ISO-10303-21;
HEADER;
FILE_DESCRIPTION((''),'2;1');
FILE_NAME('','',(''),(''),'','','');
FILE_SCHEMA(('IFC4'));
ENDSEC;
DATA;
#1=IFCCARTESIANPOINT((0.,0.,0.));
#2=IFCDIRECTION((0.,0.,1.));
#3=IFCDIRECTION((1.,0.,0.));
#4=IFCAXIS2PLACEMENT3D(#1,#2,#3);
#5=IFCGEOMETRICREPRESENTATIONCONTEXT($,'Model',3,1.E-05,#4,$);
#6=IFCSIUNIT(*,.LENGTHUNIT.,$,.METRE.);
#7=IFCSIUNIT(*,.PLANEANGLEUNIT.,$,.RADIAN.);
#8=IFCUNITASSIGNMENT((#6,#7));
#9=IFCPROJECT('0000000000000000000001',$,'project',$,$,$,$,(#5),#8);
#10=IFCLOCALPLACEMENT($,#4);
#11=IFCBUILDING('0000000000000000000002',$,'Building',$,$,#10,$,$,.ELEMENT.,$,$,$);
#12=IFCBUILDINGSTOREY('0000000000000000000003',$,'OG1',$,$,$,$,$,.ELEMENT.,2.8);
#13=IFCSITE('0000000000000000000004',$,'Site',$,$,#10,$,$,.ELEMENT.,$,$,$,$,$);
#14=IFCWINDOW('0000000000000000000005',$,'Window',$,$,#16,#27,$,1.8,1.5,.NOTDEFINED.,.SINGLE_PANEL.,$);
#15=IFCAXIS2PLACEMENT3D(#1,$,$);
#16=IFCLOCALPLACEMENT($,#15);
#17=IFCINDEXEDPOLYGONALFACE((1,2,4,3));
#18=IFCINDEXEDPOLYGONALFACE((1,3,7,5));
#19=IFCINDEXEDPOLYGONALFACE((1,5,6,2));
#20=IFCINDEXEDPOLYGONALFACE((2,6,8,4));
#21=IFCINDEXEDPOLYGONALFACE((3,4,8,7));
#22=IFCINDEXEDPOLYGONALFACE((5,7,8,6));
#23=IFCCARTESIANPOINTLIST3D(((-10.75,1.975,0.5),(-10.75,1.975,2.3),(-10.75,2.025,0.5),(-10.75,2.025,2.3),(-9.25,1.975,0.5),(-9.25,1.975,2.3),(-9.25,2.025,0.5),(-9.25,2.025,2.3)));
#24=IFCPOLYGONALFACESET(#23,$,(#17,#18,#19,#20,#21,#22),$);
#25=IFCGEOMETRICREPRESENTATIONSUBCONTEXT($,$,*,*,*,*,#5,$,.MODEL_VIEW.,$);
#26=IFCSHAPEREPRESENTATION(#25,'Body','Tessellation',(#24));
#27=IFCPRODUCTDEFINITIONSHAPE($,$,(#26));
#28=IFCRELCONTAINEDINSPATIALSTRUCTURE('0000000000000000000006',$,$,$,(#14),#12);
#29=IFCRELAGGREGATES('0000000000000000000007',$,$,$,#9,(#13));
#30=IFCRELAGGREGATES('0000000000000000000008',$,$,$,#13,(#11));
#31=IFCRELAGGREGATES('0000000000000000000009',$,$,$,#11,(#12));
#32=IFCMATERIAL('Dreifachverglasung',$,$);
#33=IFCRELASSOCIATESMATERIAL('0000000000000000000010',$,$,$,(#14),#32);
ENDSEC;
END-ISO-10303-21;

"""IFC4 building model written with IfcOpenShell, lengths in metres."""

from ifc_helpers import new_model, si_unit, frame, origin, origin_with_axes, origin_2d, place, context, subcontext, project, spatial, rectangle, extrude, material, element, save


model = new_model("IFC4")

# Units and contexts
model_context = context("Model", 3, precision=1e-05, world=origin_with_axes())
sub_context = subcontext(model_context, None, None, "MODEL_VIEW")
ifc_project = project(units=[si_unit("LENGTHUNIT", "METRE"), si_unit("PLANEANGLEUNIT", "RADIAN")], contexts=[model_context])

# Site, building, storey
placement_1 = place(None, origin_with_axes())
site = spatial("IfcSite", under=ifc_project, at=placement_1, Name="Site", CompositionType="ELEMENT")
building = spatial("IfcBuilding", under=site, at=placement_1, Name="Building", CompositionType="ELEMENT")
storey = spatial("IfcBuildingStorey", under=building, Name="OG1", CompositionType="ELEMENT", Elevation=2.8)

# Window
ifc_material = material(Name="Dreifachverglasung")
placement_2 = place(None, origin_with_axes())
window_placement = place(placement_2, frame((-10.0, 2.0, 0.5)))
element("IfcWindow", 1, at=window_placement, inside=storey, material=ifc_material, Name="Window", OverallHeight=1.8, OverallWidth=1.5, PartitioningType="SINGLE_PANEL", PredefinedType="NOTDEFINED", context=sub_context, shape_type="SweptSolid", body=[
    extrude(rectangle(XDim=1.5, YDim=0.05, at=origin_2d()), origin(), (0.0, 0.0, 1.0), 1.8),
])

save(model, "model.ifc")
